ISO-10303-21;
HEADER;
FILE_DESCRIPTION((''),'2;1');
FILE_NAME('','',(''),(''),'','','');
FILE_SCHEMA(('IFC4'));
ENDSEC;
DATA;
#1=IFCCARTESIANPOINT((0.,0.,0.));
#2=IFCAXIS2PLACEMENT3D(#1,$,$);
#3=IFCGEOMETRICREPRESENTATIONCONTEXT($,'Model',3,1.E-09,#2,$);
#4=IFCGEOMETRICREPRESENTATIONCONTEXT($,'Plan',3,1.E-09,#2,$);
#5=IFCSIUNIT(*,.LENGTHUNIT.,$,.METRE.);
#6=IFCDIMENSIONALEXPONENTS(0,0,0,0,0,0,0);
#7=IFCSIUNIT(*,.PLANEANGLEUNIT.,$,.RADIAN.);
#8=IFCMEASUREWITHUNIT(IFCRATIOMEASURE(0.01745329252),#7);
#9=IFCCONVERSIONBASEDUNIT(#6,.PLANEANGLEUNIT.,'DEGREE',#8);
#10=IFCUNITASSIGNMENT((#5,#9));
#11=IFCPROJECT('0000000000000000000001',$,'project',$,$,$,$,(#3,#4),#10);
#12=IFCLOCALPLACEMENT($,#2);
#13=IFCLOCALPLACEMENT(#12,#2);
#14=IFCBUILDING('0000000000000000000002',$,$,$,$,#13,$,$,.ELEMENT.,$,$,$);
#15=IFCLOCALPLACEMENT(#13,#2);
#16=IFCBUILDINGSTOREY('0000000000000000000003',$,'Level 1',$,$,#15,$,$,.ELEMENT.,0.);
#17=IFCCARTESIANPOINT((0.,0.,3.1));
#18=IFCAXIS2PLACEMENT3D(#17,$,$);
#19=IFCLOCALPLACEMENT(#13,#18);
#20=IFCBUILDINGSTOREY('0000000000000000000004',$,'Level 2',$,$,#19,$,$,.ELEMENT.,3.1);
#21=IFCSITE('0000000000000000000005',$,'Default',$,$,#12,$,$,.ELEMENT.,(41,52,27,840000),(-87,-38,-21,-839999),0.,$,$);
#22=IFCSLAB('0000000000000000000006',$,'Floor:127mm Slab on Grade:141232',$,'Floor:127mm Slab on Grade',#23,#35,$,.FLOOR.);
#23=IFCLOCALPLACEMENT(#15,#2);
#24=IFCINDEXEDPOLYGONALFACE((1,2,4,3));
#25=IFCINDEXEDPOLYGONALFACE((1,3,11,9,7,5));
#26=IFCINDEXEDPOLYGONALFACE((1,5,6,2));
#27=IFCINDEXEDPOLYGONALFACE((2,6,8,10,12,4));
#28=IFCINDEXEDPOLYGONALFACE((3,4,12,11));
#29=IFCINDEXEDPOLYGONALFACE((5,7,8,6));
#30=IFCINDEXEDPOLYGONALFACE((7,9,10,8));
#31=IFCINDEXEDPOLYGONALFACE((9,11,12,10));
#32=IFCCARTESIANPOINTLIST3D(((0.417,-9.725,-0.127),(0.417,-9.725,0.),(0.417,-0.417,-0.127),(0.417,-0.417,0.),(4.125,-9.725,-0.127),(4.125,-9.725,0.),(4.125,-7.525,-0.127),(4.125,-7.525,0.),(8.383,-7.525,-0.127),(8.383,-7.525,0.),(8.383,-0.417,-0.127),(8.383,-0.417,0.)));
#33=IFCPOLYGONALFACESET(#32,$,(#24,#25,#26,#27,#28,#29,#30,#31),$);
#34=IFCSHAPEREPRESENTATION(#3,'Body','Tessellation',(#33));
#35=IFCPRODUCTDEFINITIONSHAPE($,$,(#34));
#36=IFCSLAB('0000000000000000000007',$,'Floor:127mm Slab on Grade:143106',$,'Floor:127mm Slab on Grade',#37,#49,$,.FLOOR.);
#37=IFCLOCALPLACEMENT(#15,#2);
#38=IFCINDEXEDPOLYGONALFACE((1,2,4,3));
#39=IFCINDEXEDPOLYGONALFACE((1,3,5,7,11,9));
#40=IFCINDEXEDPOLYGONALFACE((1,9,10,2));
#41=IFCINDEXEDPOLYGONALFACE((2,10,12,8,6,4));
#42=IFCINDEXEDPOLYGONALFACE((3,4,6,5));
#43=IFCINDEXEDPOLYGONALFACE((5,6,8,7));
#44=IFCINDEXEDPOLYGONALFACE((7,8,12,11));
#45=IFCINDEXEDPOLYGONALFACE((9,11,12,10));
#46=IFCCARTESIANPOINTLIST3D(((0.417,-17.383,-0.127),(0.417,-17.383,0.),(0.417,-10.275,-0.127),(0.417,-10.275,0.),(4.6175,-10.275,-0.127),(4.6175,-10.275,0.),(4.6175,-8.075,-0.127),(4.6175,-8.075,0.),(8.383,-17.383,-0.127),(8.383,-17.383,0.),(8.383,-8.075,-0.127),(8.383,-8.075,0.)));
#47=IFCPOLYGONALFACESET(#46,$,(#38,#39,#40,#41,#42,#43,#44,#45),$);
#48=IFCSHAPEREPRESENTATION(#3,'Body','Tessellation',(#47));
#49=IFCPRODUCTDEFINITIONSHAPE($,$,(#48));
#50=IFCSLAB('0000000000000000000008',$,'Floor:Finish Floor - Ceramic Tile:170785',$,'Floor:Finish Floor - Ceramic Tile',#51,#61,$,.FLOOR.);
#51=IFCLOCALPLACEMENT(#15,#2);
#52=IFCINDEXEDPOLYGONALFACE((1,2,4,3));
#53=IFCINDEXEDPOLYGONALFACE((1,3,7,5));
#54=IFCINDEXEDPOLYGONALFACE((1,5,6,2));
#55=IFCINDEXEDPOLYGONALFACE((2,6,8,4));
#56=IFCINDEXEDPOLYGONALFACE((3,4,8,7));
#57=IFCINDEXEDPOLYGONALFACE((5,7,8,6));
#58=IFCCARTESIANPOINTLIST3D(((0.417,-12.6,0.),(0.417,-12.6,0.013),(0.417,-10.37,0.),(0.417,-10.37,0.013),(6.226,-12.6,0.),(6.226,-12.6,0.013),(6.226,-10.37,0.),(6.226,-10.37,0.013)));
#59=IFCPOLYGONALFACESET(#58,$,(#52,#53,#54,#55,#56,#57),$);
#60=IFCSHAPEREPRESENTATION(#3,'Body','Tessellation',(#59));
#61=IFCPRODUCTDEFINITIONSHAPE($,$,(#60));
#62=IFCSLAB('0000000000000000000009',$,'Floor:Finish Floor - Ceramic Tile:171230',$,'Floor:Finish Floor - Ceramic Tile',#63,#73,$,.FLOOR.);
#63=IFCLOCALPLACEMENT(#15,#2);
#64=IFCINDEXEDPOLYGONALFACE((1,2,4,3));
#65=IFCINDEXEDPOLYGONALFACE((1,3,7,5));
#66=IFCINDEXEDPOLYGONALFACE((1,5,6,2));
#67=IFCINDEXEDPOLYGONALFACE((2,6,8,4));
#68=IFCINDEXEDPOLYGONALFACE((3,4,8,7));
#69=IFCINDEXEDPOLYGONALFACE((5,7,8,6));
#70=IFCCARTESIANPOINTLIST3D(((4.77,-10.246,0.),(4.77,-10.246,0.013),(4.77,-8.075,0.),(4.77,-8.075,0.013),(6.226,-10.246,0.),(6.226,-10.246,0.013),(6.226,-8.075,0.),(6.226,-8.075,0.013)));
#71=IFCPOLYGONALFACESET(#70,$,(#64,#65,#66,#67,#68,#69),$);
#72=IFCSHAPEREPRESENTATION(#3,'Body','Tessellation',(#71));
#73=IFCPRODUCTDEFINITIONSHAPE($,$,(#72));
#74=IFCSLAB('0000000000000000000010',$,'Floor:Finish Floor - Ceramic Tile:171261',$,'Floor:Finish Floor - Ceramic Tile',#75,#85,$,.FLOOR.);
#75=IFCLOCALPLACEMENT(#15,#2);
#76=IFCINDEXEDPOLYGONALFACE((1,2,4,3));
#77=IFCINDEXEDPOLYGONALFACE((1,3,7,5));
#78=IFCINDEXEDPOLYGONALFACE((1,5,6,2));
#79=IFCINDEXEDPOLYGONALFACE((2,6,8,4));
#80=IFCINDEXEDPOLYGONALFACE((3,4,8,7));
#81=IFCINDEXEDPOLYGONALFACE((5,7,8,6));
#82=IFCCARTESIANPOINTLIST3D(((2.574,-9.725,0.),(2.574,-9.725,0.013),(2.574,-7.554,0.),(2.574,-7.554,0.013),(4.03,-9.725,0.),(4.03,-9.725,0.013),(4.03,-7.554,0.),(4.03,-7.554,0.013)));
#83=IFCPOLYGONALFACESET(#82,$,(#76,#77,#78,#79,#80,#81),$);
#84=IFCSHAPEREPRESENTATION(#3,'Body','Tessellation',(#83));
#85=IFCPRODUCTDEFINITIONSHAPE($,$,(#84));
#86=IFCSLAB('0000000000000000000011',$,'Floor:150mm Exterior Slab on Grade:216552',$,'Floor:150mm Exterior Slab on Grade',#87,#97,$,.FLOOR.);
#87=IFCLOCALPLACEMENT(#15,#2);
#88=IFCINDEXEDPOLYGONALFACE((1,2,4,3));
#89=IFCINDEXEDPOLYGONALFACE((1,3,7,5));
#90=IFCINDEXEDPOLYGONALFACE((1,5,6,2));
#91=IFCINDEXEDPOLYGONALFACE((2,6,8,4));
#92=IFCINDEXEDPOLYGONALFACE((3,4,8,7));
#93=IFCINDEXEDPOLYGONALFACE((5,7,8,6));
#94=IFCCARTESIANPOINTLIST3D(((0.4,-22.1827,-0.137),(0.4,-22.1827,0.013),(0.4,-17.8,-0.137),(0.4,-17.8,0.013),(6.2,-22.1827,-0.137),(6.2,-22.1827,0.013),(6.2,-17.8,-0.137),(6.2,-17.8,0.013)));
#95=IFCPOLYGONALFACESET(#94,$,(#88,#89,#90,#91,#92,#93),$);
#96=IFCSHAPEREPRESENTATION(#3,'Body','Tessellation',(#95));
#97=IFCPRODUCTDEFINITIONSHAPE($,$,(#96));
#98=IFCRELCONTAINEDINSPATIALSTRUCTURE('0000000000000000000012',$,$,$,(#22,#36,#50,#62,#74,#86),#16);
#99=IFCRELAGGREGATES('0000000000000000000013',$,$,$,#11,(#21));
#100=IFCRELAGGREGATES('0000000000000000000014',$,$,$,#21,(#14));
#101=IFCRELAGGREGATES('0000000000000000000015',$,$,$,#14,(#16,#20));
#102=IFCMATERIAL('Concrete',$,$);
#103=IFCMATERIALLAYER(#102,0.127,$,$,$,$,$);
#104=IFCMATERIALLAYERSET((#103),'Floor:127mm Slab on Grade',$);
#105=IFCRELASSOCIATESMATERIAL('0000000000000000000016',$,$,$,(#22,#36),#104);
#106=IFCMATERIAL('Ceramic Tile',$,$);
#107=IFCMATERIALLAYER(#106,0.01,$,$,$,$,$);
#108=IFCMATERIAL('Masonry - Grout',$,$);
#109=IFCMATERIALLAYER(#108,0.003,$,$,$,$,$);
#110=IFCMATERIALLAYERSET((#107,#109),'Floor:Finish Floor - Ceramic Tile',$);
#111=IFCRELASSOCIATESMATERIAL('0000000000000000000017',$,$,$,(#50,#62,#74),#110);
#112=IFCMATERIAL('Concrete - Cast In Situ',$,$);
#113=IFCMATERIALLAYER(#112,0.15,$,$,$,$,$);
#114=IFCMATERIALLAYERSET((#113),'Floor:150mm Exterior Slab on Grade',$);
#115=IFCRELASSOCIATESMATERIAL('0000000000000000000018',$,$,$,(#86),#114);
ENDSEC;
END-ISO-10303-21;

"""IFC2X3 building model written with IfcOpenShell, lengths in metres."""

from ifc_helpers import new_model, entity, si_unit, converted_unit, frame, frame_2d, origin, origin_2d_with_axis, place, context, project, spatial, polyline, rectangle, outline, extrude, material, layer, layer_set, layer_usage, element, save


model = new_model("IFC2X3")

# Units and contexts
model_context = context("Model", 3, precision=1e-09, world=origin())
plan_context = context("Plan", 3, precision=1e-09, world=origin())
ifc_project = project(units=[si_unit("LENGTHUNIT", "METRE"), converted_unit("PLANEANGLEUNIT", "DEGREE", entity("IfcRatioMeasure", 0.01745329252), si_unit("PLANEANGLEUNIT", "RADIAN"), dimensions=[0, 0, 0, 0, 0, 0, 0])], contexts=[model_context, plan_context])

# Site, building, storey
site_placement = place(None, origin())
site = spatial("IfcSite", under=ifc_project, at=site_placement, Name="Default", CompositionType="ELEMENT", RefLatitude=(41, 52, 27, 840000), RefLongitude=(-87, -38, -21, -839999), RefElevation=0.0)
building_placement = place(site_placement, origin())
building = spatial("IfcBuilding", under=site, at=building_placement, CompositionType="ELEMENT")
storey_1_placement = place(building_placement, origin())
storey_1 = spatial("IfcBuildingStorey", under=building, at=storey_1_placement, Name="Level 1", CompositionType="ELEMENT", Elevation=0.0)

# Slabs
ifc_material_1 = material(Name="Concrete")
ifc_layer_1 = layer(ifc_material_1, 0.127)
ifc_layer_set_1 = layer_set([ifc_layer_1], Name="Floor:127mm Slab on Grade")
ifc_layer_usage_1 = layer_usage(ifc_layer_set_1, "AXIS3", "POSITIVE", 0.0)
slab_1_placement = place(storey_1_placement, frame((0.417, -9.725, -0.127)))
element("IfcSlab", 1, at=slab_1_placement, inside=storey_1, material=ifc_layer_usage_1, Name="Floor:127mm Slab on Grade:141232", ObjectType="Floor:127mm Slab on Grade", PredefinedType="FLOOR", context=model_context, shape_type="SweptSolid", body=[
    extrude(outline(polyline([(-3.983, 4.654), (-3.983, -2.454), (0.275, -2.454), (0.275, -4.654), (3.983, -4.654), (3.983, 4.654), (-3.983, 4.654)])), frame((3.983, 4.654, 0.127), z_axis=(0.0, 0.0, -1.0), x_axis=(-1.0, 0.0, 0.0)), (0.0, 0.0, 1.0), 0.127),
])
ifc_layer_usage_2 = layer_usage(ifc_layer_set_1, "AXIS3", "POSITIVE", 0.0)
slab_2_placement = place(storey_1_placement, frame((0.417, -17.383, -0.127)))
element("IfcSlab", 2, at=slab_2_placement, inside=storey_1, material=ifc_layer_usage_2, Name="Floor:127mm Slab on Grade:143106", ObjectType="Floor:127mm Slab on Grade", PredefinedType="FLOOR", context=model_context, shape_type="SweptSolid", body=[
    extrude(outline(polyline([(-3.983, 4.654), (-3.983, -4.654), (3.983, -4.654), (3.983, 2.454), (-0.2175, 2.454), (-0.2175, 4.654), (-3.983, 4.654)])), frame((3.983, 4.654, 0.127), z_axis=(0.0, 0.0, -1.0), x_axis=(-1.0, 0.0, 0.0)), (0.0, 0.0, 1.0), 0.127),
])
ifc_material_2 = material(Name="Ceramic Tile")
ifc_layer_2 = layer(ifc_material_2, 0.01)
ifc_material_3 = material(Name="Masonry - Grout")
ifc_layer_3 = layer(ifc_material_3, 0.003)
ifc_layer_set_2 = layer_set([ifc_layer_2, ifc_layer_3], Name="Floor:Finish Floor - Ceramic Tile")
ifc_layer_usage_3 = layer_usage(ifc_layer_set_2, "AXIS3", "POSITIVE", 0.0)
slab_3_placement = place(storey_1_placement, frame((0.417, -12.6, 0.0)))
element("IfcSlab", 3, at=slab_3_placement, inside=storey_1, material=ifc_layer_usage_3, Name="Floor:Finish Floor - Ceramic Tile:170785", ObjectType="Floor:Finish Floor - Ceramic Tile", PredefinedType="FLOOR", context=model_context, shape_type="SweptSolid", body=[
    extrude(rectangle(XDim=5.809, YDim=2.23, at=frame_2d((0.0, 0.0), x_axis=(-1.0, 0.0))), frame((2.9045, 1.115, 0.013), z_axis=(0.0, 0.0, -1.0), x_axis=(-1.0, 0.0, 0.0)), (0.0, 0.0, 1.0), 0.013),
])
ifc_layer_usage_4 = layer_usage(ifc_layer_set_2, "AXIS3", "POSITIVE", 0.0)
slab_4_placement = place(storey_1_placement, frame((4.77, -10.246, 0.0)))
element("IfcSlab", 4, at=slab_4_placement, inside=storey_1, material=ifc_layer_usage_4, Name="Floor:Finish Floor - Ceramic Tile:171230", ObjectType="Floor:Finish Floor - Ceramic Tile", PredefinedType="FLOOR", context=model_context, shape_type="SweptSolid", body=[
    extrude(rectangle(XDim=1.456, YDim=2.171, at=frame_2d((0.0, 0.0), x_axis=(-1.0, 0.0))), frame((0.728, 1.0855, 0.013), z_axis=(0.0, 0.0, -1.0), x_axis=(-1.0, 0.0, 0.0)), (0.0, 0.0, 1.0), 0.013),
])
ifc_layer_usage_5 = layer_usage(ifc_layer_set_2, "AXIS3", "POSITIVE", 0.0)
slab_5_placement = place(storey_1_placement, frame((2.574, -9.725, 0.0)))
element("IfcSlab", 5, at=slab_5_placement, inside=storey_1, material=ifc_layer_usage_5, Name="Floor:Finish Floor - Ceramic Tile:171261", ObjectType="Floor:Finish Floor - Ceramic Tile", PredefinedType="FLOOR", context=model_context, shape_type="SweptSolid", body=[
    extrude(rectangle(XDim=2.171, YDim=1.456, at=frame_2d((0.0, 0.0), x_axis=(0.0, -1.0))), frame((0.728, 1.0855, 0.013), z_axis=(0.0, 0.0, -1.0), x_axis=(-1.0, 0.0, 0.0)), (0.0, 0.0, 1.0), 0.013),
])
ifc_material_4 = material(Name="Concrete - Cast In Situ")
ifc_layer_4 = layer(ifc_material_4, 0.15)
ifc_layer_set_3 = layer_set([ifc_layer_4], Name="Floor:150mm Exterior Slab on Grade")
ifc_layer_usage_6 = layer_usage(ifc_layer_set_3, "AXIS3", "POSITIVE", 0.0)
slab_6_placement = place(storey_1_placement, frame((0.4, -22.1827, -0.137)))
element("IfcSlab", 6, at=slab_6_placement, inside=storey_1, material=ifc_layer_usage_6, Name="Floor:150mm Exterior Slab on Grade:216552", ObjectType="Floor:150mm Exterior Slab on Grade", PredefinedType="FLOOR", context=model_context, shape_type="SweptSolid", body=[
    extrude(rectangle(XDim=5.8, YDim=4.3827, at=origin_2d_with_axis()), frame((2.9, 2.1914, 0.15), z_axis=(0.0, 0.0, -1.0), x_axis=(-1.0, 0.0, 0.0)), (0.0, 0.0, 1.0), 0.15),
])

# Shared definitions
storey_2_placement = place(building_placement, frame((0.0, 0.0, 3.1)))
storey_2 = spatial("IfcBuildingStorey", under=building, at=storey_2_placement, Name="Level 2", CompositionType="ELEMENT", Elevation=3.1)

save(model, "model.ifc")
